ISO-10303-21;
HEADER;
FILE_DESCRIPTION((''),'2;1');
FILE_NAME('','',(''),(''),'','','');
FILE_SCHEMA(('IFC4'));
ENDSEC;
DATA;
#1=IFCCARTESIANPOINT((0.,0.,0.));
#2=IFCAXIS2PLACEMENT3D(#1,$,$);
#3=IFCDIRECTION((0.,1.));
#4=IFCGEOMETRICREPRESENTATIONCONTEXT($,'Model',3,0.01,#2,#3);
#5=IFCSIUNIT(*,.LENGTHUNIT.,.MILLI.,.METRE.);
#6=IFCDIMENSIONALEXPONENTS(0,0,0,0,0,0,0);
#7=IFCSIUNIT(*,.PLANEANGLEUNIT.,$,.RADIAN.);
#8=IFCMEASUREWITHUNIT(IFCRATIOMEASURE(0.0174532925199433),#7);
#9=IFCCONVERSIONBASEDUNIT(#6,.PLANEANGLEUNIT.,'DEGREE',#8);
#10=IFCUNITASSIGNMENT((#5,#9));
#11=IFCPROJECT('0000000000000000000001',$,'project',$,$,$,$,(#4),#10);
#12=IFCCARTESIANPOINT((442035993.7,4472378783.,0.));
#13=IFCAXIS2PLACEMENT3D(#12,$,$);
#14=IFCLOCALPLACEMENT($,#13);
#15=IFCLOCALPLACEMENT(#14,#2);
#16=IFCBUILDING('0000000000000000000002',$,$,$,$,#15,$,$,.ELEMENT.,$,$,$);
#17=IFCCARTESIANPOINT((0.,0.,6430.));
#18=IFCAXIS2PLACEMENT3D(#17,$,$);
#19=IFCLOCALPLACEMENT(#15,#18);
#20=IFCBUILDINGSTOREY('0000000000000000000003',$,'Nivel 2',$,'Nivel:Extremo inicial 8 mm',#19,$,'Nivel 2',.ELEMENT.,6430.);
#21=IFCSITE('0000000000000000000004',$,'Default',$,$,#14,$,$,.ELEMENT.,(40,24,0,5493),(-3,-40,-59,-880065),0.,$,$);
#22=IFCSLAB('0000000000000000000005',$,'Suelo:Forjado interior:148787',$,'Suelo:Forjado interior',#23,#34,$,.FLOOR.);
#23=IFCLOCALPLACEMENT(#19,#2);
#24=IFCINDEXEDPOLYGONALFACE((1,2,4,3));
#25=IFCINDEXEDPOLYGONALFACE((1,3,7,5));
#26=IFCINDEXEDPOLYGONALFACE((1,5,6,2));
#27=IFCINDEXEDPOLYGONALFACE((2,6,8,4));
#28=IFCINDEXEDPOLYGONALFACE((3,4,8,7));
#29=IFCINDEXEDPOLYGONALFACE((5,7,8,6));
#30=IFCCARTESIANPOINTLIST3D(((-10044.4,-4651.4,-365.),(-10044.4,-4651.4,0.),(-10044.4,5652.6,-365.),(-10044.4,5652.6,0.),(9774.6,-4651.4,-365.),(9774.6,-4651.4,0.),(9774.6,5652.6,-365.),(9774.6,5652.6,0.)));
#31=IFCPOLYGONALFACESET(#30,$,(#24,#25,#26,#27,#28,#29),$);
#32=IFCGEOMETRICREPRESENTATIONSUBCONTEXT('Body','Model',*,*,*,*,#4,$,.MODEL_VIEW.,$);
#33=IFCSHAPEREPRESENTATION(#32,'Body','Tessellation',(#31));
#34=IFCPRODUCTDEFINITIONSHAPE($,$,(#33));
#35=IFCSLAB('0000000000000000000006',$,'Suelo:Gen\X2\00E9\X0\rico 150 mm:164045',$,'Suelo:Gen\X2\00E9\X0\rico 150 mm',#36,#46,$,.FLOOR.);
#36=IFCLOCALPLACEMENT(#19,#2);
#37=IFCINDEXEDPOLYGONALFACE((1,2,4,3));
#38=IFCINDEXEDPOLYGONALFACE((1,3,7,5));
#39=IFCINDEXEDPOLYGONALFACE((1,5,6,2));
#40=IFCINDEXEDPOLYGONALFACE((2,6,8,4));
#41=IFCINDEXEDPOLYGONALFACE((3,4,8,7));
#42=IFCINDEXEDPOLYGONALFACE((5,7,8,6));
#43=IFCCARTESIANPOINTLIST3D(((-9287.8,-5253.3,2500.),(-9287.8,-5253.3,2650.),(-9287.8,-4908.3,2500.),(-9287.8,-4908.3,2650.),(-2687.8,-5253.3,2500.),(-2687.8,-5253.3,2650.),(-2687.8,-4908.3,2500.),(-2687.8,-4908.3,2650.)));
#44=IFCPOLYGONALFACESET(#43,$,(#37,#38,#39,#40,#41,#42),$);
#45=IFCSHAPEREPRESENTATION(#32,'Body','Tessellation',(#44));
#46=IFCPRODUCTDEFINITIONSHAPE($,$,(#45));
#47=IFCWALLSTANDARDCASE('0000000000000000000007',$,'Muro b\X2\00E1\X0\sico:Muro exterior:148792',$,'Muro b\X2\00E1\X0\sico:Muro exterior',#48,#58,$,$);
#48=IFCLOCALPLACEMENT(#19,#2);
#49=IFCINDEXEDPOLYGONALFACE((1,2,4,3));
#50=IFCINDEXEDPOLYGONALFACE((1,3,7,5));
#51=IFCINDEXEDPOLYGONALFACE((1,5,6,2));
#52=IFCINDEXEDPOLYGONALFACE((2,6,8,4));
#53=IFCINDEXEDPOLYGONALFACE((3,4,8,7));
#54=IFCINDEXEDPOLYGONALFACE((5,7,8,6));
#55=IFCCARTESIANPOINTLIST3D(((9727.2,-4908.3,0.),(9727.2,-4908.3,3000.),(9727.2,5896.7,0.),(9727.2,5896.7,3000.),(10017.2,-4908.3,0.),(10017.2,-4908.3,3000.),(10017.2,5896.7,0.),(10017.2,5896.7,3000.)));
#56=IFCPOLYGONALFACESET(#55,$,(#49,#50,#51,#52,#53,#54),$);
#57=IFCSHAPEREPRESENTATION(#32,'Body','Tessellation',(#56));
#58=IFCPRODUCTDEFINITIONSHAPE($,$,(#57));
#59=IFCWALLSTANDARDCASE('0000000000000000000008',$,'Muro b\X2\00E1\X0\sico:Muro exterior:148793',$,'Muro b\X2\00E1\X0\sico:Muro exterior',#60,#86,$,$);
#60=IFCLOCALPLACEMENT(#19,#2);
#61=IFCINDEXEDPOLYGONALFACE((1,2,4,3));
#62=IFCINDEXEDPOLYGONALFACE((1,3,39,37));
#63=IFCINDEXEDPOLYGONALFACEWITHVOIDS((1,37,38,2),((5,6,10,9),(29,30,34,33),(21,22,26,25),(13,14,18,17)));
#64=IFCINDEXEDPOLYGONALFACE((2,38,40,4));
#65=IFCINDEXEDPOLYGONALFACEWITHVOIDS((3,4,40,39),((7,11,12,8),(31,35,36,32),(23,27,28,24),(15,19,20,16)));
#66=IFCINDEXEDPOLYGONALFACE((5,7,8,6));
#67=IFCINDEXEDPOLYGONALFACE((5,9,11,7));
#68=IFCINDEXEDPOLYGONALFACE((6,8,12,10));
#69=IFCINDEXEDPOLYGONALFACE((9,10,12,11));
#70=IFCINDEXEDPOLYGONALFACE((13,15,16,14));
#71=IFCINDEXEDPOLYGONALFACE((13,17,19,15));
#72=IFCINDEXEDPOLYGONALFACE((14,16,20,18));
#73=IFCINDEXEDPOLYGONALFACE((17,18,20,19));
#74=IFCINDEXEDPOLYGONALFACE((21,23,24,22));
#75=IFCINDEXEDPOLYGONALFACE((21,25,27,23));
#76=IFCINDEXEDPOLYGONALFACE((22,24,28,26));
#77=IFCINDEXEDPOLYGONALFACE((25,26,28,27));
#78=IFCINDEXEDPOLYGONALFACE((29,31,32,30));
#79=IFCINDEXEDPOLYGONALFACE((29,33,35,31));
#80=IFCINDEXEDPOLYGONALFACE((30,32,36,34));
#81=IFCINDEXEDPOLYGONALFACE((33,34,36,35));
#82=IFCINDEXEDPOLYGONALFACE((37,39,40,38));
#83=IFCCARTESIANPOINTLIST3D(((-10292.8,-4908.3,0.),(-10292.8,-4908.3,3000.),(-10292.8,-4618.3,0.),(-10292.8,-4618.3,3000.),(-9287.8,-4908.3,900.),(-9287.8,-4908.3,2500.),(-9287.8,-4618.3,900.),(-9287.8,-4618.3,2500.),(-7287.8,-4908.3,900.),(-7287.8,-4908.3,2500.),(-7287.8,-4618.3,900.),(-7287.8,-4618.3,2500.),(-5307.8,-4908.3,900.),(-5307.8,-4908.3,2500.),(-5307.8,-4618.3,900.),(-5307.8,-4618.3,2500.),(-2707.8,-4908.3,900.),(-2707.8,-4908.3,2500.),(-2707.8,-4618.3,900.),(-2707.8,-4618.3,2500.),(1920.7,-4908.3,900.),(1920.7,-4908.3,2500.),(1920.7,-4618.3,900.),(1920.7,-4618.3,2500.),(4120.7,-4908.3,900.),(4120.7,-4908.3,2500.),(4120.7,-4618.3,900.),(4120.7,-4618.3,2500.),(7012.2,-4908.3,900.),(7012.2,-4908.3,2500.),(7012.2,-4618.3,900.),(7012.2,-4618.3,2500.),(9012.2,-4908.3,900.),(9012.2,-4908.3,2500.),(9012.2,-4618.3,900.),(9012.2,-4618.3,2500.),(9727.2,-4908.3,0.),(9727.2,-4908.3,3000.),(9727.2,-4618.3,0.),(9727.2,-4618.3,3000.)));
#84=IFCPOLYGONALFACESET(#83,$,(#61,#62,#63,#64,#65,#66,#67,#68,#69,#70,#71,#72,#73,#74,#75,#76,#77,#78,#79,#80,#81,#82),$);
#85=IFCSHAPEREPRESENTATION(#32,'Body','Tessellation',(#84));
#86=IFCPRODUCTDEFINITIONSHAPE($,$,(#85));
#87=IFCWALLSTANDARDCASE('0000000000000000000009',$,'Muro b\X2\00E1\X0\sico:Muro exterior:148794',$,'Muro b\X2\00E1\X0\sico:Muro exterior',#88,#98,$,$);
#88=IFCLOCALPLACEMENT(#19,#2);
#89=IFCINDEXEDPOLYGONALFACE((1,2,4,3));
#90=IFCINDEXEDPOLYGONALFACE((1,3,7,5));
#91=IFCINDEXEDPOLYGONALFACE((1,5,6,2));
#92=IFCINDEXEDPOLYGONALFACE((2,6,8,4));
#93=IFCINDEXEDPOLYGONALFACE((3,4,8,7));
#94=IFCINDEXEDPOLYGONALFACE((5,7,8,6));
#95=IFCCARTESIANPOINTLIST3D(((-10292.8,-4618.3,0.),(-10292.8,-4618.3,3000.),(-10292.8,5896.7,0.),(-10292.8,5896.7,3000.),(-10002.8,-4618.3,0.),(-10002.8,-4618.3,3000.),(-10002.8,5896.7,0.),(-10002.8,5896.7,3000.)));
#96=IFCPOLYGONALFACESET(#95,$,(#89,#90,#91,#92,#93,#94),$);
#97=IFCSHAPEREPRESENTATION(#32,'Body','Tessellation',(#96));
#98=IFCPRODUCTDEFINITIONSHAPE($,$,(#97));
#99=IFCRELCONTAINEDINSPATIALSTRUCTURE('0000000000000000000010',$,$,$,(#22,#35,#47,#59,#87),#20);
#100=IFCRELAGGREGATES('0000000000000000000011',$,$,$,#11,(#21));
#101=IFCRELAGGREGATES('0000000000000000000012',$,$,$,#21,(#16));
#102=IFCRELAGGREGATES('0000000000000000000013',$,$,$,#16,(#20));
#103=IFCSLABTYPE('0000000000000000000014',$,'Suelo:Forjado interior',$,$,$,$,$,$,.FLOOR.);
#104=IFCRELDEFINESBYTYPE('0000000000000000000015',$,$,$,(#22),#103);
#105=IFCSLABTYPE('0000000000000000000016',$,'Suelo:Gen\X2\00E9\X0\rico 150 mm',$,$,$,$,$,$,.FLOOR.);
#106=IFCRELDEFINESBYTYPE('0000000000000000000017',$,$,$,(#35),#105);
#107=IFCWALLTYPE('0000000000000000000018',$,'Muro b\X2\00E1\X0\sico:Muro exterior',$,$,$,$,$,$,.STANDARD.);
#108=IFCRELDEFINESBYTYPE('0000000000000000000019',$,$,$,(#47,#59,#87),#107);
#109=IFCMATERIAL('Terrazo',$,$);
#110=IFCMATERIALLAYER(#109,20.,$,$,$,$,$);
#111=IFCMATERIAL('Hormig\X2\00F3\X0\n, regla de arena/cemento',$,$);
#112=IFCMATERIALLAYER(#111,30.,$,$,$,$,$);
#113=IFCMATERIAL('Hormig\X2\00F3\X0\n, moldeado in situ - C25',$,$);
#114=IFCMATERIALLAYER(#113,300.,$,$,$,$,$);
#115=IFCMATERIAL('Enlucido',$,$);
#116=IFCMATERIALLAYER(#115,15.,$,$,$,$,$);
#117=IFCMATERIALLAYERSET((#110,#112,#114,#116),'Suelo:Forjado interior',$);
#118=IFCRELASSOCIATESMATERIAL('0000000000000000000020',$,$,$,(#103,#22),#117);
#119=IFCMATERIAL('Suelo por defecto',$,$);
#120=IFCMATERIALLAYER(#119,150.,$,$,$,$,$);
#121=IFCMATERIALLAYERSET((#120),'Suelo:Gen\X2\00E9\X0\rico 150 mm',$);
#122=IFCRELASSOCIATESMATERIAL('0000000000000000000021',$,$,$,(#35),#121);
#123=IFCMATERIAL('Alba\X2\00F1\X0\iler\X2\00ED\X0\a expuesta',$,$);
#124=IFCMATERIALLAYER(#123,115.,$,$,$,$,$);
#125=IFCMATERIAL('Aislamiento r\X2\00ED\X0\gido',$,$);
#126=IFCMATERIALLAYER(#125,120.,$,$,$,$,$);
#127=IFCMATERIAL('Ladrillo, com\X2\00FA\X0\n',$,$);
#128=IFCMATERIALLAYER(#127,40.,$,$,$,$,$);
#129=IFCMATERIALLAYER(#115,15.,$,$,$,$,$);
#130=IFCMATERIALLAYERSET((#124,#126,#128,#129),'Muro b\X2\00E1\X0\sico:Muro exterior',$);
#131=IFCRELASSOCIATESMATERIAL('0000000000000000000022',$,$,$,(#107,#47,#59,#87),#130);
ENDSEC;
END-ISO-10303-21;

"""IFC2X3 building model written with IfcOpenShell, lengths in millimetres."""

from ifc_helpers import new_model, entity, si_unit, converted_unit, direction, frame, frame_2d, origin, origin_2d_with_axis, place, context, subcontext, project, spatial, polyline, rectangle, extrude, clip, bounded_halfspace, material, layer, layer_set, layer_usage, type_object, element, save


model = new_model("IFC2X3")

# Units and contexts
model_context = context("Model", 3, precision=0.01, world=origin(), true_north=direction((0.0, 1.0)))
body_context = subcontext(model_context, "Body", "Model", "MODEL_VIEW")
ifc_project = project(units=[si_unit("LENGTHUNIT", "METRE", prefix="MILLI"), converted_unit("PLANEANGLEUNIT", "DEGREE", entity("IfcRatioMeasure", 0.0174532925199433), si_unit("PLANEANGLEUNIT", "RADIAN"), dimensions=[0, 0, 0, 0, 0, 0, 0])], contexts=[model_context])

# Site, building, storey
site_placement = place(None, frame((442035993.7, 4472378783.0, 0.0)))
site = spatial("IfcSite", under=ifc_project, at=site_placement, Name="Default", CompositionType="ELEMENT", RefLatitude=(40, 24, 0, 5493), RefLongitude=(-3, -40, -59, -880065), RefElevation=0.0)
building_placement = place(site_placement, origin())
building = spatial("IfcBuilding", under=site, at=building_placement, CompositionType="ELEMENT")
storey_placement = place(building_placement, frame((0.0, 0.0, 6430.0)))
storey = spatial("IfcBuildingStorey", under=building, at=storey_placement, Name="Nivel 2", ObjectType="Nivel:Extremo inicial 8 mm", LongName="Nivel 2", CompositionType="ELEMENT", Elevation=6430.0)

# Slabs
ifc_material_1 = material(Name="Terrazo")
ifc_layer_1 = layer(ifc_material_1, 20.0)
ifc_material_2 = material(Name="Hormigón, regla de arena/cemento")
ifc_layer_2 = layer(ifc_material_2, 30.0)
ifc_material_3 = material(Name="Hormigón, moldeado in situ - C25")
ifc_layer_3 = layer(ifc_material_3, 300.0)
ifc_material_4 = material(Name="Enlucido")
ifc_layer_4 = layer(ifc_material_4, 15.0)
ifc_layer_set_1 = layer_set([ifc_layer_1, ifc_layer_2, ifc_layer_3, ifc_layer_4], Name="Suelo:Forjado interior")
ifc_layer_usage_1 = layer_usage(ifc_layer_set_1, "AXIS3", "POSITIVE", 0.0)
slab_type_1 = type_object("IfcSlabType", Name="Suelo:Forjado interior", PredefinedType="FLOOR", material=ifc_layer_set_1)
slab_1_placement = place(storey_placement, origin())
element("IfcSlab", 1, at=slab_1_placement, inside=storey, type_object=slab_type_1, material=ifc_layer_usage_1, Name="Suelo:Forjado interior:148787", ObjectType="Suelo:Forjado interior", PredefinedType="FLOOR", context=body_context, shape_type="SweptSolid", body=[
    extrude(rectangle(XDim=10304.0, YDim=19819.0, at=origin_2d_with_axis()), frame((-134.9, 500.6, 0.0), z_axis=(0.0, 0.0, -1.0), x_axis=(0.0, 1.0, 0.0)), (0.0, 0.0, 1.0), 365.0),
])
ifc_material_5 = material(Name="Suelo por defecto")
ifc_layer_5 = layer(ifc_material_5, 150.0)
ifc_layer_set_2 = layer_set([ifc_layer_5], Name="Suelo:Genérico 150 mm")
ifc_layer_usage_2 = layer_usage(ifc_layer_set_2, "AXIS3", "POSITIVE", 0.0)
slab_type_2 = type_object("IfcSlabType", Name="Suelo:Genérico 150 mm", PredefinedType="FLOOR")
slab_2_placement = place(storey_placement, frame((-9287.8, -5253.3, 2500.0)))
element("IfcSlab", 2, at=slab_2_placement, inside=storey, type_object=slab_type_2, material=ifc_layer_usage_2, Name="Suelo:Genérico 150 mm:164045", ObjectType="Suelo:Genérico 150 mm", PredefinedType="FLOOR", context=body_context, shape_type="SweptSolid", body=[
    extrude(rectangle(XDim=6600.0, YDim=345.0, at=frame_2d((5850.0, 0.0), x_axis=(1.0, 0.0))), frame((9150.0, 172.5, 150.0), z_axis=(0.0, 0.0, -1.0), x_axis=(-1.0, 0.0, 0.0)), (0.0, 0.0, 1.0), 150.0),
])

# Wall
ifc_material_6 = material(Name="Albañilería expuesta")
ifc_layer_6 = layer(ifc_material_6, 115.0)
ifc_material_7 = material(Name="Aislamiento rígido")
ifc_layer_7 = layer(ifc_material_7, 120.0)
ifc_material_8 = material(Name="Ladrillo, común")
ifc_layer_8 = layer(ifc_material_8, 40.0)
ifc_layer_9 = layer(ifc_material_4, 15.0)
ifc_layer_set_3 = layer_set([ifc_layer_6, ifc_layer_7, ifc_layer_8, ifc_layer_9], Name="Muro básico:Muro exterior")
ifc_layer_usage_3 = layer_usage(ifc_layer_set_3, "AXIS2", "NEGATIVE", 145.0)
wall_type_1 = type_object("IfcWallType", Name="Muro básico:Muro exterior", PredefinedType="STANDARD", material=ifc_layer_set_3)
wall_1_placement = place(storey_placement, frame((9872.2, 5896.7, 0.0), z_axis=(0.0, 0.0, 1.0), x_axis=(0.0, -1.0, 0.0)))
element("IfcWallStandardCase", 3, at=wall_1_placement, inside=storey, type_object=wall_type_1, material=ifc_layer_usage_3, Name="Muro básico:Muro exterior:148792", ObjectType="Muro básico:Muro exterior", context=body_context, shape_type="Clipping", body=[
    clip(extrude(rectangle(XDim=10805.0, YDim=290.0, at=frame_2d((5402.5, 0.0), x_axis=(-1.0, 0.0))), origin(), (0.0, 0.0, 1.0), 3000.0), bounded_halfspace(frame((0.0, -145.0, 3000.0), z_axis=(0.0, 0.0, 1.0), x_axis=(-1.0, 0.0, 0.0)), False, frame((0.0, -145.0, 3000.0), z_axis=(0.0, 0.0, 1.0), x_axis=(-1.0, 0.0, 0.0)), polyline([(0.0, 0.0), (-290.0, 0.0), (-10515.0, 0.0), (-10805.0, 0.0), (-10805.0, -290.0), (0.0, -290.0), (0.0, 0.0)]))),
])

# Wall, openings
ifc_layer_usage_4 = layer_usage(ifc_layer_set_3, "AXIS2", "NEGATIVE", 145.0)
wall_2_placement = place(storey_placement, frame((9727.2, -4763.3, 0.0), z_axis=(0.0, 0.0, 1.0), x_axis=(-1.0, 0.0, 0.0)))
wall_2 = element("IfcWallStandardCase", 4, at=wall_2_placement, inside=storey, type_object=wall_type_1, material=ifc_layer_usage_4, Name="Muro básico:Muro exterior:148793", ObjectType="Muro básico:Muro exterior", context=body_context, shape_type="Clipping", body=[
    clip(extrude(rectangle(XDim=20020.0, YDim=290.0, at=frame_2d((10010.0, 0.0), x_axis=(-1.0, 0.0))), origin(), (0.0, 0.0, 1.0), 3000.0), bounded_halfspace(frame((0.0, -145.0, 3000.0), z_axis=(0.0, 0.0, 1.0), x_axis=(0.0, -1.0, 0.0)), False, frame((0.0, -145.0, 3000.0), z_axis=(0.0, 0.0, 1.0), x_axis=(0.0, -1.0, 0.0)), polyline([(0.0, 0.0), (0.0, 9762.5), (0.0, 9907.5), (0.0, 19730.0), (0.0, 20020.0), (-290.0, 20020.0), (-290.0, 0.0), (0.0, 0.0)]))),
])
opening_1_placement = place(wall_2_placement, frame((19015.0, 145.0, 900.0)))
element("IfcOpeningElement", 5, at=opening_1_placement, cuts=wall_2, ObjectType="Opening", context=body_context, shape_type="SweptSolid", body=[
    extrude(rectangle(XDim=1600.0, YDim=2000.0, at=frame_2d((800.0, 1000.0), x_axis=(1.0, 0.0))), frame((0.0, 0.0, 0.0), z_axis=(0.0, -1.0, 0.0), x_axis=(0.0, 0.0, 1.0)), (0.0, 0.0, 1.0), 290.0),
])
opening_2_placement = place(wall_2_placement, frame((15035.0, 145.0, 900.0)))
element("IfcOpeningElement", 6, at=opening_2_placement, cuts=wall_2, ObjectType="Opening", context=body_context, shape_type="SweptSolid", body=[
    extrude(rectangle(XDim=1600.0, YDim=2600.0, at=frame_2d((800.0, 1300.0), x_axis=(1.0, 0.0))), frame((0.0, 0.0, 0.0), z_axis=(0.0, -1.0, 0.0), x_axis=(0.0, 0.0, 1.0)), (0.0, 0.0, 1.0), 290.0),
])
opening_3_placement = place(wall_2_placement, frame((7806.5, 145.0, 900.0)))
element("IfcOpeningElement", 7, at=opening_3_placement, cuts=wall_2, ObjectType="Opening", context=body_context, shape_type="SweptSolid", body=[
    extrude(rectangle(XDim=1600.0, YDim=2200.0, at=frame_2d((800.0, 1100.0), x_axis=(1.0, 0.0))), frame((0.0, 0.0, 0.0), z_axis=(0.0, -1.0, 0.0), x_axis=(0.0, 0.0, 1.0)), (0.0, 0.0, 1.0), 290.0),
])
opening_4_placement = place(wall_2_placement, frame((2715.0, 145.0, 900.0)))
element("IfcOpeningElement", 8, at=opening_4_placement, cuts=wall_2, ObjectType="Opening", context=body_context, shape_type="SweptSolid", body=[
    extrude(rectangle(XDim=1600.0, YDim=2000.0, at=frame_2d((800.0, 1000.0), x_axis=(1.0, 0.0))), frame((0.0, 0.0, 0.0), z_axis=(0.0, -1.0, 0.0), x_axis=(0.0, 0.0, 1.0)), (0.0, 0.0, 1.0), 290.0),
])

# Wall
ifc_layer_usage_5 = layer_usage(ifc_layer_set_3, "AXIS2", "NEGATIVE", 145.0)
wall_3_placement = place(storey_placement, frame((-10147.8, -4618.3, 0.0), z_axis=(0.0, 0.0, 1.0), x_axis=(0.0, 1.0, 0.0)))
element("IfcWallStandardCase", 9, at=wall_3_placement, inside=storey, type_object=wall_type_1, material=ifc_layer_usage_5, Name="Muro básico:Muro exterior:148794", ObjectType="Muro básico:Muro exterior", context=body_context, shape_type="Clipping", body=[
    clip(extrude(rectangle(XDim=10515.0, YDim=290.0, at=frame_2d((5257.5, 0.0), x_axis=(-1.0, 0.0))), origin(), (0.0, 0.0, 1.0), 3000.0), bounded_halfspace(frame((0.0, -145.0, 3000.0)), False, frame((0.0, -145.0, 3000.0)), polyline([(0.0, 0.0), (10225.0, 0.0), (10515.0, 0.0), (10515.0, 290.0), (0.0, 290.0), (0.0, 0.0)]))),
])

save(model, "model.ifc")
